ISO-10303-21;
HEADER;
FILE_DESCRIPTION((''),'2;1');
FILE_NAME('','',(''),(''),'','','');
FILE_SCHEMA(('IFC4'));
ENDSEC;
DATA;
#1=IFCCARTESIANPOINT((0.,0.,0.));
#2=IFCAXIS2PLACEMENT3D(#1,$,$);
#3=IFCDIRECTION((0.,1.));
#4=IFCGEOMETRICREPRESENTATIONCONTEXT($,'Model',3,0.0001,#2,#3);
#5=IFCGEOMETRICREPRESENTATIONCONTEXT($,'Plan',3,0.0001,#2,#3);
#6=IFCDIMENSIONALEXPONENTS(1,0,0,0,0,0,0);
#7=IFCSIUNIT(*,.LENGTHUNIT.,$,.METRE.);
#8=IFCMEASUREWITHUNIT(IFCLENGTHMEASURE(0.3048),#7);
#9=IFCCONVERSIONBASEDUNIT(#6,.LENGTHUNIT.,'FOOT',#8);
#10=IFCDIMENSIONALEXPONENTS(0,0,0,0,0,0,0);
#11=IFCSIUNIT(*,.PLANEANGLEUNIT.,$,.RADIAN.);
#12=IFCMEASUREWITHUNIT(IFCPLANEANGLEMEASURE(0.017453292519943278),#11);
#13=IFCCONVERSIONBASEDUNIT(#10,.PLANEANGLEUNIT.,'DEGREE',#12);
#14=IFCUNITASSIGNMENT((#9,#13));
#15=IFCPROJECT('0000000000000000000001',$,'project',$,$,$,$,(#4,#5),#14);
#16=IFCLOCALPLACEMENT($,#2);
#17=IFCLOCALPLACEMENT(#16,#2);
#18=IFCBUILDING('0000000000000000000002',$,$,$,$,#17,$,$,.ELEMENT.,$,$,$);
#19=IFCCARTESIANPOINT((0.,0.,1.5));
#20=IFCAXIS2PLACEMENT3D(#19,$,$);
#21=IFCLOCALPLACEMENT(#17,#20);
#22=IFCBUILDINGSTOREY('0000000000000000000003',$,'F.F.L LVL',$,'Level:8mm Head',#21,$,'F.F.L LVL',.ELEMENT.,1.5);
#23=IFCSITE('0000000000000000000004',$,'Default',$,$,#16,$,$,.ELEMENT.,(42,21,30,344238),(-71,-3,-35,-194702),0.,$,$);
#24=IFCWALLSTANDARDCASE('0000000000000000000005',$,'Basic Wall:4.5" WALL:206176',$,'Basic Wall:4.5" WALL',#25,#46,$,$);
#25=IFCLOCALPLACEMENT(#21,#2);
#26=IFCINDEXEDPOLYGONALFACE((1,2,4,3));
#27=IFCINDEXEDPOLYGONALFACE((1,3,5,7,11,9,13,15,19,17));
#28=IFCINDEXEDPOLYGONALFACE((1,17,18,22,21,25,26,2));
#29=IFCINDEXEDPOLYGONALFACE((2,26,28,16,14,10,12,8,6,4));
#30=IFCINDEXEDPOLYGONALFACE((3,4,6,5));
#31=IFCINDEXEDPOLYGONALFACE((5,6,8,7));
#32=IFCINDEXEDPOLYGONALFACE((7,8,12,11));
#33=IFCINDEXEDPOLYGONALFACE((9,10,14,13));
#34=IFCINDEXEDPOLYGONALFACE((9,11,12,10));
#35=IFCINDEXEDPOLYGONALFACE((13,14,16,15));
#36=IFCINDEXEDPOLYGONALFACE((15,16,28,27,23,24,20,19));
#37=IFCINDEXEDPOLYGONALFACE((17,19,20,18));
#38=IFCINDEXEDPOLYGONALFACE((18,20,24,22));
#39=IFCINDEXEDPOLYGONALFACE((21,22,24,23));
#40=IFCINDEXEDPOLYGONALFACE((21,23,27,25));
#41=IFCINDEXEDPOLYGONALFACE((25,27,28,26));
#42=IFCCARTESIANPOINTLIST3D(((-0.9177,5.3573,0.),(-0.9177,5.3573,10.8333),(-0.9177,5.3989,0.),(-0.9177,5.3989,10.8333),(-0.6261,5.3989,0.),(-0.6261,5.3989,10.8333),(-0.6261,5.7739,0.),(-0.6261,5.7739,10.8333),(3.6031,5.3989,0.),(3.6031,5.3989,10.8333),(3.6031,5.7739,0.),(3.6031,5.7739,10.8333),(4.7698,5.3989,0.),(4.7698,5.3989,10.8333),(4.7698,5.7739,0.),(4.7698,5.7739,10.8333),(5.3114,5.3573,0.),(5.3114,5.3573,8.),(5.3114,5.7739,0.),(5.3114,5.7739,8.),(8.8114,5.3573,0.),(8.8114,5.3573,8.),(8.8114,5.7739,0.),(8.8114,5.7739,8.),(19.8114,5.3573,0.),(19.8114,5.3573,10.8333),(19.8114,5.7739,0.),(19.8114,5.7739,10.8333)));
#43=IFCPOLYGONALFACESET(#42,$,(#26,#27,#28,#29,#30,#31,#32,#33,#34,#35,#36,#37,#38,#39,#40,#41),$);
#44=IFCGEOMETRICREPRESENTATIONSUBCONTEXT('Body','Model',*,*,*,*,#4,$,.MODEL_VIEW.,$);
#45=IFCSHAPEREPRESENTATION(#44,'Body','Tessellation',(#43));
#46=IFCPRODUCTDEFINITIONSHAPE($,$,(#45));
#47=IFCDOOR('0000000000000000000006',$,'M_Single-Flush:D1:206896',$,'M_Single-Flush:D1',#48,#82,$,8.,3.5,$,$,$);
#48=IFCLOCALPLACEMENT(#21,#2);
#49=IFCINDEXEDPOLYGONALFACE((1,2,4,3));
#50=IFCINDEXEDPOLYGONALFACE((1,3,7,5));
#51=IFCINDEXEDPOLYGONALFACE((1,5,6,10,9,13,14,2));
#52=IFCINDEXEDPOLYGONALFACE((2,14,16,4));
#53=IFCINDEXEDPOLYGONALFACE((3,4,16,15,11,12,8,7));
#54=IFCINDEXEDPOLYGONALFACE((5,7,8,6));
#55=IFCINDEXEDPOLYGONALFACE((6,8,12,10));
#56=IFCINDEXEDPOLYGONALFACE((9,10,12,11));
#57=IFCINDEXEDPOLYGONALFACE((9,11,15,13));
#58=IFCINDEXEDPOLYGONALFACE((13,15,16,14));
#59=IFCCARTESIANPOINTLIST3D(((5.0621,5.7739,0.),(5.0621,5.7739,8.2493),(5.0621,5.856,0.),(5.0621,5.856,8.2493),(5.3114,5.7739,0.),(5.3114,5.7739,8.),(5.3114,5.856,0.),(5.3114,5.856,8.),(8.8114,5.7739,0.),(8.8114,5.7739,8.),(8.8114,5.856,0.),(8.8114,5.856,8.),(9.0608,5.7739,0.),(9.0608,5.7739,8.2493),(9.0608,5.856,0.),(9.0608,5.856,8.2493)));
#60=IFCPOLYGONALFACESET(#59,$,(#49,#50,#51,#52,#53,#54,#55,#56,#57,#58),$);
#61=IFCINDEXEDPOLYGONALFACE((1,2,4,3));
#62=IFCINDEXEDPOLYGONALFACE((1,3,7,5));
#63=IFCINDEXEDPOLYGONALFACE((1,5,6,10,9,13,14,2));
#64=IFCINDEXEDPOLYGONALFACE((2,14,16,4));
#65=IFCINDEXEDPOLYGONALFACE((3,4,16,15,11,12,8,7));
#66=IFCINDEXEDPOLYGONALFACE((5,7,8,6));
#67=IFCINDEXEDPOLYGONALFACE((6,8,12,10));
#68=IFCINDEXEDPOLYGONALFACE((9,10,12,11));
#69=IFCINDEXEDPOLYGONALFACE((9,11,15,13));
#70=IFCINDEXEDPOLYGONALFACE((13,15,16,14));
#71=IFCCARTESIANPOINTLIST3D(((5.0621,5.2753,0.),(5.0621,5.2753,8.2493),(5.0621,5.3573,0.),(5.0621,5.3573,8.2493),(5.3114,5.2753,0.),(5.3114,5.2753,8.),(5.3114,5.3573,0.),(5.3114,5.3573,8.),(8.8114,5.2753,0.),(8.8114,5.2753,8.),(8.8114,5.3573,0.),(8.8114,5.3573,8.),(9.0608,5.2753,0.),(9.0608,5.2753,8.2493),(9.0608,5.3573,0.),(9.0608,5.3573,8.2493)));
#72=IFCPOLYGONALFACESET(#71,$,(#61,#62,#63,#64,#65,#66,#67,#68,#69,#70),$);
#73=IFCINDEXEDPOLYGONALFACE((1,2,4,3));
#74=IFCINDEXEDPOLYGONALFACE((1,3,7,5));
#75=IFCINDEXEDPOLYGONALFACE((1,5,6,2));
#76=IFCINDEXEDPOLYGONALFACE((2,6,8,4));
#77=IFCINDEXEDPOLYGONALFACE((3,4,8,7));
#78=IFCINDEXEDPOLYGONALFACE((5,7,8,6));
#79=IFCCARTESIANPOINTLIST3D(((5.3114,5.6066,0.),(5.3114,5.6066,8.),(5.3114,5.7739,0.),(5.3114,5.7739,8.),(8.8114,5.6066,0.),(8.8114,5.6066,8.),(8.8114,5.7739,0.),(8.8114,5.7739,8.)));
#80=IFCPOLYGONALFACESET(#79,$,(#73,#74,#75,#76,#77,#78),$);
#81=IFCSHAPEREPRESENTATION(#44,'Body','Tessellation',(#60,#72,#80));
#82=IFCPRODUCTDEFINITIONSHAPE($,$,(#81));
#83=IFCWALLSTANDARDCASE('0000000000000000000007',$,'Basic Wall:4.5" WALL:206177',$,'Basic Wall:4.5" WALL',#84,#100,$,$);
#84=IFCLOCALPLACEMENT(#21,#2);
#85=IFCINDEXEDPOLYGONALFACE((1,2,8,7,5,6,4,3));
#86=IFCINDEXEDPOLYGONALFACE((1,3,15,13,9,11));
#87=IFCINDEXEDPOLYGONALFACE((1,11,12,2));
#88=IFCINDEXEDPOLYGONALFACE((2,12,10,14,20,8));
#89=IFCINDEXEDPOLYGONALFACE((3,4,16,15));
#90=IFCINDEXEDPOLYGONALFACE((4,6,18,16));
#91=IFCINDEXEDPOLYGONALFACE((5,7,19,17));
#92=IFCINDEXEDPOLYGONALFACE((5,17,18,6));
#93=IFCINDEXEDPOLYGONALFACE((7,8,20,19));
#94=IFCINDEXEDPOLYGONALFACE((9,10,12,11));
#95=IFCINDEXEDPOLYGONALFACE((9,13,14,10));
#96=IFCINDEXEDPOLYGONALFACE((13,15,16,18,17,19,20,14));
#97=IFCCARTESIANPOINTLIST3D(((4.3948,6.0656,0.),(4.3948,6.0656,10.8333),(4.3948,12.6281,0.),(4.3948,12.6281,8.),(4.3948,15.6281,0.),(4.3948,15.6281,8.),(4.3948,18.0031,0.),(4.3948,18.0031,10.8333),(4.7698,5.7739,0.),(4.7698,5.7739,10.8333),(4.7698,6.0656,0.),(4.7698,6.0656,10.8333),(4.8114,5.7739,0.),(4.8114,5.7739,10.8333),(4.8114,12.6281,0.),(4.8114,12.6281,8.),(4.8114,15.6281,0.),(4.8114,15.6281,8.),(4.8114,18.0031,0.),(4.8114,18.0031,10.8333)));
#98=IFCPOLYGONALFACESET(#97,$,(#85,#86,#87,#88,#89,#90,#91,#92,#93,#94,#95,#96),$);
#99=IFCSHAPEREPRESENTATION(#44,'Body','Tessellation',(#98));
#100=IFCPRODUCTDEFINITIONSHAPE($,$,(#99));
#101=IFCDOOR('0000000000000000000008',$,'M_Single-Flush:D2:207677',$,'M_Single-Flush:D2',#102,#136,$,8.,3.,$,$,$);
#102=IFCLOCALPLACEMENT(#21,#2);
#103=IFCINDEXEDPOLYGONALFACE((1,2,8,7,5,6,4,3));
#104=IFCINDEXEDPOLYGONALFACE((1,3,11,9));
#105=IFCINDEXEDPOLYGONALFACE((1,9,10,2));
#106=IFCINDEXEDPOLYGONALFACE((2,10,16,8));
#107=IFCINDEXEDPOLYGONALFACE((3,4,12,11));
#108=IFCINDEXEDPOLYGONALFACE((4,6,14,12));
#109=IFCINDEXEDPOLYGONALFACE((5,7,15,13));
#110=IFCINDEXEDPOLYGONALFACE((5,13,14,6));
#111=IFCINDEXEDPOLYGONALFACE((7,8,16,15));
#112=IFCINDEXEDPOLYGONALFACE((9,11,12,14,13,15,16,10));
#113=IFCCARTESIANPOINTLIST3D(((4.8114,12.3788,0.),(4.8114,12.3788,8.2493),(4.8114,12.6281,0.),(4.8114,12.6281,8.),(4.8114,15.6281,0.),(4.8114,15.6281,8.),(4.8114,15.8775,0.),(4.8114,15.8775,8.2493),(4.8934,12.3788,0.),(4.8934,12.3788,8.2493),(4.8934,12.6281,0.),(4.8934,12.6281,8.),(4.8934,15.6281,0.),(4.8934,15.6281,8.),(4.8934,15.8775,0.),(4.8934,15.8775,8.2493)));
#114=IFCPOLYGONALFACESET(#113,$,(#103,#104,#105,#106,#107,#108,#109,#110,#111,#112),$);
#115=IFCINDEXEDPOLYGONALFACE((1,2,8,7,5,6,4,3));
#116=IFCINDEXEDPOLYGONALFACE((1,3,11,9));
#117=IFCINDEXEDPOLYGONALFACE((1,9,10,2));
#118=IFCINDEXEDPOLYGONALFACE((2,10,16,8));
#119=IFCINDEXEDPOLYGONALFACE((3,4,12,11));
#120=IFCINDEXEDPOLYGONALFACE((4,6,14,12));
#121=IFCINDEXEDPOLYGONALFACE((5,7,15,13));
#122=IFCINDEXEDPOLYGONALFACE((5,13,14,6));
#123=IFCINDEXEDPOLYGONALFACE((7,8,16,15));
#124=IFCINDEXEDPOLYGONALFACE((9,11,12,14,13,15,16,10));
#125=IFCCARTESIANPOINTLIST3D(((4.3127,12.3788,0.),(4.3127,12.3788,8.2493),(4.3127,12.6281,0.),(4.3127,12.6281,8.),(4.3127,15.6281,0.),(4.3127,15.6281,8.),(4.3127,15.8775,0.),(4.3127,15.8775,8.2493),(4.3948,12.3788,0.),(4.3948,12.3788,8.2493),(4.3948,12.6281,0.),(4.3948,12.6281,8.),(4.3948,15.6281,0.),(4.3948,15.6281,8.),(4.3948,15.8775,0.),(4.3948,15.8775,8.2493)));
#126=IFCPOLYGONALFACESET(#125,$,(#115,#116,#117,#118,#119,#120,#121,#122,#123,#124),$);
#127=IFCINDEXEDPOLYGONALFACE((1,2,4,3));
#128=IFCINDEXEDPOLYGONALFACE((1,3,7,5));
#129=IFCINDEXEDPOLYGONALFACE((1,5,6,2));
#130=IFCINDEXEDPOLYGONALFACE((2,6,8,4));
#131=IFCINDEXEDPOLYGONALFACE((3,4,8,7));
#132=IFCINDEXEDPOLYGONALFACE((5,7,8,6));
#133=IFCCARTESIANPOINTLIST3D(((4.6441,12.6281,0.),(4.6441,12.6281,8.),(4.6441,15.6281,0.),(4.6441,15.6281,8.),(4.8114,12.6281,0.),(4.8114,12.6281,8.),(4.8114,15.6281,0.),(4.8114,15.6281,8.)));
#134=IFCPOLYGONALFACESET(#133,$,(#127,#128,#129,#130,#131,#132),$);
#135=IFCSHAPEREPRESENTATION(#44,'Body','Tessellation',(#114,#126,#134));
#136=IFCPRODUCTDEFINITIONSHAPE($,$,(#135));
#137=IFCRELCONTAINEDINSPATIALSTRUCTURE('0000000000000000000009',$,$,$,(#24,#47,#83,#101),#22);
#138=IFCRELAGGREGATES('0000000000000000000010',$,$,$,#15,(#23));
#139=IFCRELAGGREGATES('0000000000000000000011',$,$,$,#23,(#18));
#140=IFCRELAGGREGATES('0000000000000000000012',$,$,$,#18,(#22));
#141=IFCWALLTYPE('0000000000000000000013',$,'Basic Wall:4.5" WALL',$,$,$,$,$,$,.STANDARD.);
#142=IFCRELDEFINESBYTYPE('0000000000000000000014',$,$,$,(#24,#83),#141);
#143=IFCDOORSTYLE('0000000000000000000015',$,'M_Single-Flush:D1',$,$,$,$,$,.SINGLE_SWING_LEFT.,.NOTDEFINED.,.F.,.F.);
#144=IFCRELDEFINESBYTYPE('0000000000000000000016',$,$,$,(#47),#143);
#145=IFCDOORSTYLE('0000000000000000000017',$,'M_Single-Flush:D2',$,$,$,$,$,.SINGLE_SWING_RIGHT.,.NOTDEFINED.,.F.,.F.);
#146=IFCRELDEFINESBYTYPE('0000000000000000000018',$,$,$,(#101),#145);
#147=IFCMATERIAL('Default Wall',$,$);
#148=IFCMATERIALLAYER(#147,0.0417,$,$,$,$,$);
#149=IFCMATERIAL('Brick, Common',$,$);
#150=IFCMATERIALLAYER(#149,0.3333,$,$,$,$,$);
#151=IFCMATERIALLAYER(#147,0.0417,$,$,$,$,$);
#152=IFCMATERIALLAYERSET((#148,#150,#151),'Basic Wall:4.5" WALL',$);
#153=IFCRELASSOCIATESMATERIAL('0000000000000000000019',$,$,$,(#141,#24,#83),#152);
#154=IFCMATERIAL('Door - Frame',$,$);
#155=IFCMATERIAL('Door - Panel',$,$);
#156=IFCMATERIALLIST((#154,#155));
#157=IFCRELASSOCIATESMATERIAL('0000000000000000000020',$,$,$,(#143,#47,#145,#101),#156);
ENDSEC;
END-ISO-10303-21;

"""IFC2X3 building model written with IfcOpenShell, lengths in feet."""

from ifc_helpers import new_model, entity, si_unit, converted_unit, direction, frame, frame_2d, origin, origin_2d_with_axis, place, context, subcontext, project, spatial, polyline, rectangle, outline, extrude, clip, bounded_halfspace, source, transform, mapped, material, material_list, layer, layer_set, layer_usage, type_object, type_shapes, element, fill, save


model = new_model("IFC2X3")

# Units and contexts
model_context = context("Model", 3, precision=0.0001, world=origin(), true_north=direction((0.0, 1.0)))
plan_context = context("Plan", 3, precision=0.0001, world=origin(), true_north=direction((0.0, 1.0)))
body_context = subcontext(model_context, "Body", "Model", "MODEL_VIEW")
ifc_project = project(units=[converted_unit("LENGTHUNIT", "FOOT", entity("IfcLengthMeasure", 0.3048), si_unit("LENGTHUNIT", "METRE"), dimensions=[1, 0, 0, 0, 0, 0, 0]), converted_unit("PLANEANGLEUNIT", "DEGREE", entity("IfcPlaneAngleMeasure", 0.017453292519943278), si_unit("PLANEANGLEUNIT", "RADIAN"), dimensions=[0, 0, 0, 0, 0, 0, 0])], contexts=[model_context, plan_context])

# Site, building, storey
site_placement = place(None, origin())
site = spatial("IfcSite", under=ifc_project, at=site_placement, Name="Default", CompositionType="ELEMENT", RefLatitude=(42, 21, 30, 344238), RefLongitude=(-71, -3, -35, -194702), RefElevation=0.0)
building_placement = place(site_placement, origin())
building = spatial("IfcBuilding", under=site, at=building_placement, CompositionType="ELEMENT")
storey_placement = place(building_placement, frame((0.0, 0.0, 1.5)))
storey = spatial("IfcBuildingStorey", under=building, at=storey_placement, Name="F.F.L LVL", ObjectType="Level:8mm Head", LongName="F.F.L LVL", CompositionType="ELEMENT", Elevation=1.5)

# Shared definitions
ifc_material_1 = material(Name="Default Wall")
ifc_material_2 = material(Name="Brick, Common")

# Shared definitions
ifc_material_3 = material(Name="Door - Panel")
ifc_material_4 = material(Name="Door - Frame")

# Shared definitions
ifc_layer_1 = layer(ifc_material_1, 0.0417)
ifc_layer_2 = layer(ifc_material_2, 0.3333)
ifc_layer_3 = layer(ifc_material_1, 0.0417)
ifc_layer_set_1 = layer_set([ifc_layer_1, ifc_layer_2, ifc_layer_3], Name="Basic Wall:4.5\" WALL")
wall_type_1 = type_object("IfcWallType", Name="Basic Wall:4.5\" WALL", PredefinedType="STANDARD", material=ifc_layer_set_1)
ifc_material_list_1 = material_list([ifc_material_4, ifc_material_3])
door_style_1 = type_object("IfcDoorStyle", Name="M_Single-Flush:D1", ConstructionType="NOTDEFINED", OperationType="SINGLE_SWING_LEFT", ParameterTakesPrecedence=False, Sizeable=False, material=ifc_material_list_1)
shared_shape_1 = source(origin(), body_context, "Body", "SweptSolid", [
    extrude(outline(polyline([(-1.9993, -4.187), (1.9993, -4.187), (1.9993, 4.0623), (1.75, 4.0623), (1.75, -3.9377), (-1.75, -3.9377), (-1.75, 4.0623), (-1.9993, 4.0623), (-1.9993, -4.187)])), frame((1.75, 0.4987, 4.0623), z_axis=(0.0, -1.0, 0.0), x_axis=(-1.0, 0.0, 0.0)), (0.0, 0.0, 1.0), 0.082),
    extrude(outline(polyline([(-4.187, -1.9993), (4.0623, -1.9993), (4.0623, -1.75), (-3.9377, -1.75), (-3.9377, 1.75), (4.0623, 1.75), (4.0623, 1.9993), (-4.187, 1.9993), (-4.187, -1.9993)])), frame((1.75, 0.0, 4.0623), z_axis=(0.0, -1.0, 0.0), x_axis=(0.0, 0.0, -1.0)), (0.0, 0.0, 1.0), 0.082),
    extrude(rectangle(XDim=3.5, YDim=0.1673, at=origin_2d_with_axis()), frame((1.75, 0.333, 0.0)), (0.0, 0.0, 1.0), 8.0),
])
type_shapes(door_style_1, [shared_shape_1])

# Walls, openings, doors
ifc_layer_usage_1 = layer_usage(ifc_layer_set_1, "AXIS2", "NEGATIVE", 0.2083)
wall_1_placement = place(storey_placement, frame((-0.9177, 5.5656, 0.0)))
wall_1 = element("IfcWallStandardCase", 1, at=wall_1_placement, inside=storey, type_object=wall_type_1, material=ifc_layer_usage_1, Name="Basic Wall:4.5\" WALL:206176", ObjectType="Basic Wall:4.5\" WALL", context=body_context, shape_type="Clipping", body=[
    clip(clip(clip(extrude(rectangle(XDim=20.7292, YDim=0.4167, at=frame_2d((10.3646, 0.0), x_axis=(-1.0, 0.0))), origin(), (0.0, 0.0, 1.0), 10.8333), bounded_halfspace(frame((5.6875, -0.1667, 10.8333), z_axis=(0.0, -1.0, 0.0), x_axis=(0.0, 0.0, -1.0)), True, frame((5.6875, -0.1667, 10.8333), z_axis=(0.0, -1.0, 0.0), x_axis=(0.0, 0.0, -1.0)), polyline([(0.0, 0.0), (0.0, -1.1667), (10.8333, -1.1667), (10.8333, 0.0), (0.0, 0.0)]))), bounded_halfspace(frame((0.2917, -0.1667, 0.0), z_axis=(1.0, 0.0, 0.0), x_axis=(0.0, 0.0, -1.0)), True, frame((0.2917, -0.1667, 0.0), z_axis=(1.0, 0.0, 0.0), x_axis=(0.0, 0.0, -1.0)), polyline([(0.0, 0.0), (0.0, 0.375), (-10.8333, 0.375), (-10.8333, 0.0), (0.0, 0.0)]))), bounded_halfspace(frame((0.2917, -0.1667, 10.8333), z_axis=(0.0, -1.0, 0.0), x_axis=(0.0, 0.0, -1.0)), True, frame((0.2917, -0.1667, 10.8333), z_axis=(0.0, -1.0, 0.0), x_axis=(0.0, 0.0, -1.0)), polyline([(0.0, 0.0), (0.0, -0.2917), (10.8333, -0.2917), (10.8333, 0.0), (0.0, 0.0)]))),
])
opening_1_placement = place(wall_1_placement, frame((6.2292, -0.2083, 0.0)))
opening_1 = element("IfcOpeningElement", 2, at=opening_1_placement, cuts=wall_1, ObjectType="Opening", context=body_context, shape_type="SweptSolid", body=[
    extrude(rectangle(XDim=3.5, YDim=8.0, at=frame_2d((4.0, 1.75), x_axis=(0.0, -1.0))), frame((0.0, 0.0, 0.0), z_axis=(0.0, 1.0, 0.0), x_axis=(0.0, 0.0, 1.0)), (0.0, 0.0, 1.0), 0.4167),
])
door_1_placement = place(opening_1_placement, origin())
door_1 = element("IfcDoor", 3, at=door_1_placement, inside=storey, type_object=door_style_1, material=ifc_material_list_1, Name="M_Single-Flush:D1:206896", ObjectType="M_Single-Flush:D1", OverallHeight=8.0, OverallWidth=3.5, context=body_context, shape_type="MappedRepresentation", body=[
    mapped(shared_shape_1, transform((0.0, 0.0, 0.0), scale=1.0)),
])
fill(opening_1, door_1)
ifc_layer_usage_2 = layer_usage(ifc_layer_set_1, "AXIS2", "NEGATIVE", 0.2083)
wall_2_placement = place(storey_placement, frame((4.6031, 5.7739, 0.0), z_axis=(0.0, 0.0, 1.0), x_axis=(0.0, 1.0, 0.0)))
wall_2 = element("IfcWallStandardCase", 4, at=wall_2_placement, inside=storey, type_object=wall_type_1, material=ifc_layer_usage_2, Name="Basic Wall:4.5\" WALL:206177", ObjectType="Basic Wall:4.5\" WALL", context=body_context, shape_type="Clipping", body=[
    clip(clip(extrude(rectangle(XDim=12.2292, YDim=0.4167, at=frame_2d((6.1146, 0.0), x_axis=(-1.0, 0.0))), origin(), (0.0, 0.0, 1.0), 10.8333), bounded_halfspace(frame((0.2917, -0.1667, 0.0), z_axis=(1.0, 0.0, 0.0), x_axis=(0.0, 0.0, -1.0)), True, frame((0.2917, -0.1667, 0.0), z_axis=(1.0, 0.0, 0.0), x_axis=(0.0, 0.0, -1.0)), polyline([(0.0, 0.0), (0.0, 0.375), (-10.8333, 0.375), (-10.8333, 0.0), (0.0, 0.0)]))), bounded_halfspace(frame((0.2917, -0.1667, 10.8333), z_axis=(0.0, -1.0, 0.0), x_axis=(0.0, 0.0, -1.0)), True, frame((0.2917, -0.1667, 10.8333), z_axis=(0.0, -1.0, 0.0), x_axis=(0.0, 0.0, -1.0)), polyline([(0.0, 0.0), (0.0, -0.2917), (10.8333, -0.2917), (10.8333, 0.0), (0.0, 0.0)]))),
])
opening_2_placement = place(wall_2_placement, frame((9.8542, 0.2083, 0.0)))
opening_2 = element("IfcOpeningElement", 5, at=opening_2_placement, cuts=wall_2, ObjectType="Opening", context=body_context, shape_type="SweptSolid", body=[
    extrude(rectangle(XDim=3.0, YDim=8.0, at=frame_2d((4.0, 1.5), x_axis=(0.0, 1.0))), frame((0.0, 0.0, 0.0), z_axis=(0.0, -1.0, 0.0), x_axis=(0.0, 0.0, 1.0)), (0.0, 0.0, 1.0), 0.4167),
])
door_style_2 = type_object("IfcDoorStyle", Name="M_Single-Flush:D2", ConstructionType="NOTDEFINED", OperationType="SINGLE_SWING_RIGHT", ParameterTakesPrecedence=False, Sizeable=False, material=ifc_material_list_1)
shared_shape_2 = source(origin(), body_context, "Body", "SweptSolid", [
    extrude(outline(polyline([(-1.7493, -4.187), (1.7493, -4.187), (1.7493, 4.0623), (1.5, 4.0623), (1.5, -3.9377), (-1.5, -3.9377), (-1.5, 4.0623), (-1.7493, 4.0623), (-1.7493, -4.187)])), frame((1.5, 0.4167, 4.0623), z_axis=(0.0, 1.0, 0.0), x_axis=(1.0, 0.0, 0.0)), (0.0, 0.0, 1.0), 0.082),
    extrude(outline(polyline([(-4.187, -1.7493), (4.0623, -1.7493), (4.0623, -1.5), (-3.9377, -1.5), (-3.9377, 1.5), (4.0623, 1.5), (4.0623, 1.7493), (-4.187, 1.7493), (-4.187, -1.7493)])), frame((1.5, -0.082, 4.0623), z_axis=(0.0, 1.0, 0.0), x_axis=(0.0, 0.0, -1.0)), (0.0, 0.0, 1.0), 0.082),
    extrude(rectangle(XDim=0.1673, YDim=3.0, at=frame_2d((0.0, 0.0), x_axis=(1.0, 0.0))), frame((1.5, 0.333, 0.0), z_axis=(0.0, 0.0, 1.0), x_axis=(0.0, 1.0, 0.0)), (0.0, 0.0, 1.0), 8.0),
])
type_shapes(door_style_2, [shared_shape_2])
door_2_placement = place(opening_2_placement, frame((0.0, 0.0, 0.0), z_axis=(0.0, 0.0, 1.0), x_axis=(-1.0, 0.0, 0.0)))
door_2 = element("IfcDoor", 6, at=door_2_placement, inside=storey, type_object=door_style_2, material=ifc_material_list_1, Name="M_Single-Flush:D2:207677", ObjectType="M_Single-Flush:D2", OverallHeight=8.0, OverallWidth=3.0, context=body_context, shape_type="MappedRepresentation", body=[
    mapped(shared_shape_2, transform((0.0, 0.0, 0.0), scale=1.0)),
])
fill(opening_2, door_2)

save(model, "model.ifc")
